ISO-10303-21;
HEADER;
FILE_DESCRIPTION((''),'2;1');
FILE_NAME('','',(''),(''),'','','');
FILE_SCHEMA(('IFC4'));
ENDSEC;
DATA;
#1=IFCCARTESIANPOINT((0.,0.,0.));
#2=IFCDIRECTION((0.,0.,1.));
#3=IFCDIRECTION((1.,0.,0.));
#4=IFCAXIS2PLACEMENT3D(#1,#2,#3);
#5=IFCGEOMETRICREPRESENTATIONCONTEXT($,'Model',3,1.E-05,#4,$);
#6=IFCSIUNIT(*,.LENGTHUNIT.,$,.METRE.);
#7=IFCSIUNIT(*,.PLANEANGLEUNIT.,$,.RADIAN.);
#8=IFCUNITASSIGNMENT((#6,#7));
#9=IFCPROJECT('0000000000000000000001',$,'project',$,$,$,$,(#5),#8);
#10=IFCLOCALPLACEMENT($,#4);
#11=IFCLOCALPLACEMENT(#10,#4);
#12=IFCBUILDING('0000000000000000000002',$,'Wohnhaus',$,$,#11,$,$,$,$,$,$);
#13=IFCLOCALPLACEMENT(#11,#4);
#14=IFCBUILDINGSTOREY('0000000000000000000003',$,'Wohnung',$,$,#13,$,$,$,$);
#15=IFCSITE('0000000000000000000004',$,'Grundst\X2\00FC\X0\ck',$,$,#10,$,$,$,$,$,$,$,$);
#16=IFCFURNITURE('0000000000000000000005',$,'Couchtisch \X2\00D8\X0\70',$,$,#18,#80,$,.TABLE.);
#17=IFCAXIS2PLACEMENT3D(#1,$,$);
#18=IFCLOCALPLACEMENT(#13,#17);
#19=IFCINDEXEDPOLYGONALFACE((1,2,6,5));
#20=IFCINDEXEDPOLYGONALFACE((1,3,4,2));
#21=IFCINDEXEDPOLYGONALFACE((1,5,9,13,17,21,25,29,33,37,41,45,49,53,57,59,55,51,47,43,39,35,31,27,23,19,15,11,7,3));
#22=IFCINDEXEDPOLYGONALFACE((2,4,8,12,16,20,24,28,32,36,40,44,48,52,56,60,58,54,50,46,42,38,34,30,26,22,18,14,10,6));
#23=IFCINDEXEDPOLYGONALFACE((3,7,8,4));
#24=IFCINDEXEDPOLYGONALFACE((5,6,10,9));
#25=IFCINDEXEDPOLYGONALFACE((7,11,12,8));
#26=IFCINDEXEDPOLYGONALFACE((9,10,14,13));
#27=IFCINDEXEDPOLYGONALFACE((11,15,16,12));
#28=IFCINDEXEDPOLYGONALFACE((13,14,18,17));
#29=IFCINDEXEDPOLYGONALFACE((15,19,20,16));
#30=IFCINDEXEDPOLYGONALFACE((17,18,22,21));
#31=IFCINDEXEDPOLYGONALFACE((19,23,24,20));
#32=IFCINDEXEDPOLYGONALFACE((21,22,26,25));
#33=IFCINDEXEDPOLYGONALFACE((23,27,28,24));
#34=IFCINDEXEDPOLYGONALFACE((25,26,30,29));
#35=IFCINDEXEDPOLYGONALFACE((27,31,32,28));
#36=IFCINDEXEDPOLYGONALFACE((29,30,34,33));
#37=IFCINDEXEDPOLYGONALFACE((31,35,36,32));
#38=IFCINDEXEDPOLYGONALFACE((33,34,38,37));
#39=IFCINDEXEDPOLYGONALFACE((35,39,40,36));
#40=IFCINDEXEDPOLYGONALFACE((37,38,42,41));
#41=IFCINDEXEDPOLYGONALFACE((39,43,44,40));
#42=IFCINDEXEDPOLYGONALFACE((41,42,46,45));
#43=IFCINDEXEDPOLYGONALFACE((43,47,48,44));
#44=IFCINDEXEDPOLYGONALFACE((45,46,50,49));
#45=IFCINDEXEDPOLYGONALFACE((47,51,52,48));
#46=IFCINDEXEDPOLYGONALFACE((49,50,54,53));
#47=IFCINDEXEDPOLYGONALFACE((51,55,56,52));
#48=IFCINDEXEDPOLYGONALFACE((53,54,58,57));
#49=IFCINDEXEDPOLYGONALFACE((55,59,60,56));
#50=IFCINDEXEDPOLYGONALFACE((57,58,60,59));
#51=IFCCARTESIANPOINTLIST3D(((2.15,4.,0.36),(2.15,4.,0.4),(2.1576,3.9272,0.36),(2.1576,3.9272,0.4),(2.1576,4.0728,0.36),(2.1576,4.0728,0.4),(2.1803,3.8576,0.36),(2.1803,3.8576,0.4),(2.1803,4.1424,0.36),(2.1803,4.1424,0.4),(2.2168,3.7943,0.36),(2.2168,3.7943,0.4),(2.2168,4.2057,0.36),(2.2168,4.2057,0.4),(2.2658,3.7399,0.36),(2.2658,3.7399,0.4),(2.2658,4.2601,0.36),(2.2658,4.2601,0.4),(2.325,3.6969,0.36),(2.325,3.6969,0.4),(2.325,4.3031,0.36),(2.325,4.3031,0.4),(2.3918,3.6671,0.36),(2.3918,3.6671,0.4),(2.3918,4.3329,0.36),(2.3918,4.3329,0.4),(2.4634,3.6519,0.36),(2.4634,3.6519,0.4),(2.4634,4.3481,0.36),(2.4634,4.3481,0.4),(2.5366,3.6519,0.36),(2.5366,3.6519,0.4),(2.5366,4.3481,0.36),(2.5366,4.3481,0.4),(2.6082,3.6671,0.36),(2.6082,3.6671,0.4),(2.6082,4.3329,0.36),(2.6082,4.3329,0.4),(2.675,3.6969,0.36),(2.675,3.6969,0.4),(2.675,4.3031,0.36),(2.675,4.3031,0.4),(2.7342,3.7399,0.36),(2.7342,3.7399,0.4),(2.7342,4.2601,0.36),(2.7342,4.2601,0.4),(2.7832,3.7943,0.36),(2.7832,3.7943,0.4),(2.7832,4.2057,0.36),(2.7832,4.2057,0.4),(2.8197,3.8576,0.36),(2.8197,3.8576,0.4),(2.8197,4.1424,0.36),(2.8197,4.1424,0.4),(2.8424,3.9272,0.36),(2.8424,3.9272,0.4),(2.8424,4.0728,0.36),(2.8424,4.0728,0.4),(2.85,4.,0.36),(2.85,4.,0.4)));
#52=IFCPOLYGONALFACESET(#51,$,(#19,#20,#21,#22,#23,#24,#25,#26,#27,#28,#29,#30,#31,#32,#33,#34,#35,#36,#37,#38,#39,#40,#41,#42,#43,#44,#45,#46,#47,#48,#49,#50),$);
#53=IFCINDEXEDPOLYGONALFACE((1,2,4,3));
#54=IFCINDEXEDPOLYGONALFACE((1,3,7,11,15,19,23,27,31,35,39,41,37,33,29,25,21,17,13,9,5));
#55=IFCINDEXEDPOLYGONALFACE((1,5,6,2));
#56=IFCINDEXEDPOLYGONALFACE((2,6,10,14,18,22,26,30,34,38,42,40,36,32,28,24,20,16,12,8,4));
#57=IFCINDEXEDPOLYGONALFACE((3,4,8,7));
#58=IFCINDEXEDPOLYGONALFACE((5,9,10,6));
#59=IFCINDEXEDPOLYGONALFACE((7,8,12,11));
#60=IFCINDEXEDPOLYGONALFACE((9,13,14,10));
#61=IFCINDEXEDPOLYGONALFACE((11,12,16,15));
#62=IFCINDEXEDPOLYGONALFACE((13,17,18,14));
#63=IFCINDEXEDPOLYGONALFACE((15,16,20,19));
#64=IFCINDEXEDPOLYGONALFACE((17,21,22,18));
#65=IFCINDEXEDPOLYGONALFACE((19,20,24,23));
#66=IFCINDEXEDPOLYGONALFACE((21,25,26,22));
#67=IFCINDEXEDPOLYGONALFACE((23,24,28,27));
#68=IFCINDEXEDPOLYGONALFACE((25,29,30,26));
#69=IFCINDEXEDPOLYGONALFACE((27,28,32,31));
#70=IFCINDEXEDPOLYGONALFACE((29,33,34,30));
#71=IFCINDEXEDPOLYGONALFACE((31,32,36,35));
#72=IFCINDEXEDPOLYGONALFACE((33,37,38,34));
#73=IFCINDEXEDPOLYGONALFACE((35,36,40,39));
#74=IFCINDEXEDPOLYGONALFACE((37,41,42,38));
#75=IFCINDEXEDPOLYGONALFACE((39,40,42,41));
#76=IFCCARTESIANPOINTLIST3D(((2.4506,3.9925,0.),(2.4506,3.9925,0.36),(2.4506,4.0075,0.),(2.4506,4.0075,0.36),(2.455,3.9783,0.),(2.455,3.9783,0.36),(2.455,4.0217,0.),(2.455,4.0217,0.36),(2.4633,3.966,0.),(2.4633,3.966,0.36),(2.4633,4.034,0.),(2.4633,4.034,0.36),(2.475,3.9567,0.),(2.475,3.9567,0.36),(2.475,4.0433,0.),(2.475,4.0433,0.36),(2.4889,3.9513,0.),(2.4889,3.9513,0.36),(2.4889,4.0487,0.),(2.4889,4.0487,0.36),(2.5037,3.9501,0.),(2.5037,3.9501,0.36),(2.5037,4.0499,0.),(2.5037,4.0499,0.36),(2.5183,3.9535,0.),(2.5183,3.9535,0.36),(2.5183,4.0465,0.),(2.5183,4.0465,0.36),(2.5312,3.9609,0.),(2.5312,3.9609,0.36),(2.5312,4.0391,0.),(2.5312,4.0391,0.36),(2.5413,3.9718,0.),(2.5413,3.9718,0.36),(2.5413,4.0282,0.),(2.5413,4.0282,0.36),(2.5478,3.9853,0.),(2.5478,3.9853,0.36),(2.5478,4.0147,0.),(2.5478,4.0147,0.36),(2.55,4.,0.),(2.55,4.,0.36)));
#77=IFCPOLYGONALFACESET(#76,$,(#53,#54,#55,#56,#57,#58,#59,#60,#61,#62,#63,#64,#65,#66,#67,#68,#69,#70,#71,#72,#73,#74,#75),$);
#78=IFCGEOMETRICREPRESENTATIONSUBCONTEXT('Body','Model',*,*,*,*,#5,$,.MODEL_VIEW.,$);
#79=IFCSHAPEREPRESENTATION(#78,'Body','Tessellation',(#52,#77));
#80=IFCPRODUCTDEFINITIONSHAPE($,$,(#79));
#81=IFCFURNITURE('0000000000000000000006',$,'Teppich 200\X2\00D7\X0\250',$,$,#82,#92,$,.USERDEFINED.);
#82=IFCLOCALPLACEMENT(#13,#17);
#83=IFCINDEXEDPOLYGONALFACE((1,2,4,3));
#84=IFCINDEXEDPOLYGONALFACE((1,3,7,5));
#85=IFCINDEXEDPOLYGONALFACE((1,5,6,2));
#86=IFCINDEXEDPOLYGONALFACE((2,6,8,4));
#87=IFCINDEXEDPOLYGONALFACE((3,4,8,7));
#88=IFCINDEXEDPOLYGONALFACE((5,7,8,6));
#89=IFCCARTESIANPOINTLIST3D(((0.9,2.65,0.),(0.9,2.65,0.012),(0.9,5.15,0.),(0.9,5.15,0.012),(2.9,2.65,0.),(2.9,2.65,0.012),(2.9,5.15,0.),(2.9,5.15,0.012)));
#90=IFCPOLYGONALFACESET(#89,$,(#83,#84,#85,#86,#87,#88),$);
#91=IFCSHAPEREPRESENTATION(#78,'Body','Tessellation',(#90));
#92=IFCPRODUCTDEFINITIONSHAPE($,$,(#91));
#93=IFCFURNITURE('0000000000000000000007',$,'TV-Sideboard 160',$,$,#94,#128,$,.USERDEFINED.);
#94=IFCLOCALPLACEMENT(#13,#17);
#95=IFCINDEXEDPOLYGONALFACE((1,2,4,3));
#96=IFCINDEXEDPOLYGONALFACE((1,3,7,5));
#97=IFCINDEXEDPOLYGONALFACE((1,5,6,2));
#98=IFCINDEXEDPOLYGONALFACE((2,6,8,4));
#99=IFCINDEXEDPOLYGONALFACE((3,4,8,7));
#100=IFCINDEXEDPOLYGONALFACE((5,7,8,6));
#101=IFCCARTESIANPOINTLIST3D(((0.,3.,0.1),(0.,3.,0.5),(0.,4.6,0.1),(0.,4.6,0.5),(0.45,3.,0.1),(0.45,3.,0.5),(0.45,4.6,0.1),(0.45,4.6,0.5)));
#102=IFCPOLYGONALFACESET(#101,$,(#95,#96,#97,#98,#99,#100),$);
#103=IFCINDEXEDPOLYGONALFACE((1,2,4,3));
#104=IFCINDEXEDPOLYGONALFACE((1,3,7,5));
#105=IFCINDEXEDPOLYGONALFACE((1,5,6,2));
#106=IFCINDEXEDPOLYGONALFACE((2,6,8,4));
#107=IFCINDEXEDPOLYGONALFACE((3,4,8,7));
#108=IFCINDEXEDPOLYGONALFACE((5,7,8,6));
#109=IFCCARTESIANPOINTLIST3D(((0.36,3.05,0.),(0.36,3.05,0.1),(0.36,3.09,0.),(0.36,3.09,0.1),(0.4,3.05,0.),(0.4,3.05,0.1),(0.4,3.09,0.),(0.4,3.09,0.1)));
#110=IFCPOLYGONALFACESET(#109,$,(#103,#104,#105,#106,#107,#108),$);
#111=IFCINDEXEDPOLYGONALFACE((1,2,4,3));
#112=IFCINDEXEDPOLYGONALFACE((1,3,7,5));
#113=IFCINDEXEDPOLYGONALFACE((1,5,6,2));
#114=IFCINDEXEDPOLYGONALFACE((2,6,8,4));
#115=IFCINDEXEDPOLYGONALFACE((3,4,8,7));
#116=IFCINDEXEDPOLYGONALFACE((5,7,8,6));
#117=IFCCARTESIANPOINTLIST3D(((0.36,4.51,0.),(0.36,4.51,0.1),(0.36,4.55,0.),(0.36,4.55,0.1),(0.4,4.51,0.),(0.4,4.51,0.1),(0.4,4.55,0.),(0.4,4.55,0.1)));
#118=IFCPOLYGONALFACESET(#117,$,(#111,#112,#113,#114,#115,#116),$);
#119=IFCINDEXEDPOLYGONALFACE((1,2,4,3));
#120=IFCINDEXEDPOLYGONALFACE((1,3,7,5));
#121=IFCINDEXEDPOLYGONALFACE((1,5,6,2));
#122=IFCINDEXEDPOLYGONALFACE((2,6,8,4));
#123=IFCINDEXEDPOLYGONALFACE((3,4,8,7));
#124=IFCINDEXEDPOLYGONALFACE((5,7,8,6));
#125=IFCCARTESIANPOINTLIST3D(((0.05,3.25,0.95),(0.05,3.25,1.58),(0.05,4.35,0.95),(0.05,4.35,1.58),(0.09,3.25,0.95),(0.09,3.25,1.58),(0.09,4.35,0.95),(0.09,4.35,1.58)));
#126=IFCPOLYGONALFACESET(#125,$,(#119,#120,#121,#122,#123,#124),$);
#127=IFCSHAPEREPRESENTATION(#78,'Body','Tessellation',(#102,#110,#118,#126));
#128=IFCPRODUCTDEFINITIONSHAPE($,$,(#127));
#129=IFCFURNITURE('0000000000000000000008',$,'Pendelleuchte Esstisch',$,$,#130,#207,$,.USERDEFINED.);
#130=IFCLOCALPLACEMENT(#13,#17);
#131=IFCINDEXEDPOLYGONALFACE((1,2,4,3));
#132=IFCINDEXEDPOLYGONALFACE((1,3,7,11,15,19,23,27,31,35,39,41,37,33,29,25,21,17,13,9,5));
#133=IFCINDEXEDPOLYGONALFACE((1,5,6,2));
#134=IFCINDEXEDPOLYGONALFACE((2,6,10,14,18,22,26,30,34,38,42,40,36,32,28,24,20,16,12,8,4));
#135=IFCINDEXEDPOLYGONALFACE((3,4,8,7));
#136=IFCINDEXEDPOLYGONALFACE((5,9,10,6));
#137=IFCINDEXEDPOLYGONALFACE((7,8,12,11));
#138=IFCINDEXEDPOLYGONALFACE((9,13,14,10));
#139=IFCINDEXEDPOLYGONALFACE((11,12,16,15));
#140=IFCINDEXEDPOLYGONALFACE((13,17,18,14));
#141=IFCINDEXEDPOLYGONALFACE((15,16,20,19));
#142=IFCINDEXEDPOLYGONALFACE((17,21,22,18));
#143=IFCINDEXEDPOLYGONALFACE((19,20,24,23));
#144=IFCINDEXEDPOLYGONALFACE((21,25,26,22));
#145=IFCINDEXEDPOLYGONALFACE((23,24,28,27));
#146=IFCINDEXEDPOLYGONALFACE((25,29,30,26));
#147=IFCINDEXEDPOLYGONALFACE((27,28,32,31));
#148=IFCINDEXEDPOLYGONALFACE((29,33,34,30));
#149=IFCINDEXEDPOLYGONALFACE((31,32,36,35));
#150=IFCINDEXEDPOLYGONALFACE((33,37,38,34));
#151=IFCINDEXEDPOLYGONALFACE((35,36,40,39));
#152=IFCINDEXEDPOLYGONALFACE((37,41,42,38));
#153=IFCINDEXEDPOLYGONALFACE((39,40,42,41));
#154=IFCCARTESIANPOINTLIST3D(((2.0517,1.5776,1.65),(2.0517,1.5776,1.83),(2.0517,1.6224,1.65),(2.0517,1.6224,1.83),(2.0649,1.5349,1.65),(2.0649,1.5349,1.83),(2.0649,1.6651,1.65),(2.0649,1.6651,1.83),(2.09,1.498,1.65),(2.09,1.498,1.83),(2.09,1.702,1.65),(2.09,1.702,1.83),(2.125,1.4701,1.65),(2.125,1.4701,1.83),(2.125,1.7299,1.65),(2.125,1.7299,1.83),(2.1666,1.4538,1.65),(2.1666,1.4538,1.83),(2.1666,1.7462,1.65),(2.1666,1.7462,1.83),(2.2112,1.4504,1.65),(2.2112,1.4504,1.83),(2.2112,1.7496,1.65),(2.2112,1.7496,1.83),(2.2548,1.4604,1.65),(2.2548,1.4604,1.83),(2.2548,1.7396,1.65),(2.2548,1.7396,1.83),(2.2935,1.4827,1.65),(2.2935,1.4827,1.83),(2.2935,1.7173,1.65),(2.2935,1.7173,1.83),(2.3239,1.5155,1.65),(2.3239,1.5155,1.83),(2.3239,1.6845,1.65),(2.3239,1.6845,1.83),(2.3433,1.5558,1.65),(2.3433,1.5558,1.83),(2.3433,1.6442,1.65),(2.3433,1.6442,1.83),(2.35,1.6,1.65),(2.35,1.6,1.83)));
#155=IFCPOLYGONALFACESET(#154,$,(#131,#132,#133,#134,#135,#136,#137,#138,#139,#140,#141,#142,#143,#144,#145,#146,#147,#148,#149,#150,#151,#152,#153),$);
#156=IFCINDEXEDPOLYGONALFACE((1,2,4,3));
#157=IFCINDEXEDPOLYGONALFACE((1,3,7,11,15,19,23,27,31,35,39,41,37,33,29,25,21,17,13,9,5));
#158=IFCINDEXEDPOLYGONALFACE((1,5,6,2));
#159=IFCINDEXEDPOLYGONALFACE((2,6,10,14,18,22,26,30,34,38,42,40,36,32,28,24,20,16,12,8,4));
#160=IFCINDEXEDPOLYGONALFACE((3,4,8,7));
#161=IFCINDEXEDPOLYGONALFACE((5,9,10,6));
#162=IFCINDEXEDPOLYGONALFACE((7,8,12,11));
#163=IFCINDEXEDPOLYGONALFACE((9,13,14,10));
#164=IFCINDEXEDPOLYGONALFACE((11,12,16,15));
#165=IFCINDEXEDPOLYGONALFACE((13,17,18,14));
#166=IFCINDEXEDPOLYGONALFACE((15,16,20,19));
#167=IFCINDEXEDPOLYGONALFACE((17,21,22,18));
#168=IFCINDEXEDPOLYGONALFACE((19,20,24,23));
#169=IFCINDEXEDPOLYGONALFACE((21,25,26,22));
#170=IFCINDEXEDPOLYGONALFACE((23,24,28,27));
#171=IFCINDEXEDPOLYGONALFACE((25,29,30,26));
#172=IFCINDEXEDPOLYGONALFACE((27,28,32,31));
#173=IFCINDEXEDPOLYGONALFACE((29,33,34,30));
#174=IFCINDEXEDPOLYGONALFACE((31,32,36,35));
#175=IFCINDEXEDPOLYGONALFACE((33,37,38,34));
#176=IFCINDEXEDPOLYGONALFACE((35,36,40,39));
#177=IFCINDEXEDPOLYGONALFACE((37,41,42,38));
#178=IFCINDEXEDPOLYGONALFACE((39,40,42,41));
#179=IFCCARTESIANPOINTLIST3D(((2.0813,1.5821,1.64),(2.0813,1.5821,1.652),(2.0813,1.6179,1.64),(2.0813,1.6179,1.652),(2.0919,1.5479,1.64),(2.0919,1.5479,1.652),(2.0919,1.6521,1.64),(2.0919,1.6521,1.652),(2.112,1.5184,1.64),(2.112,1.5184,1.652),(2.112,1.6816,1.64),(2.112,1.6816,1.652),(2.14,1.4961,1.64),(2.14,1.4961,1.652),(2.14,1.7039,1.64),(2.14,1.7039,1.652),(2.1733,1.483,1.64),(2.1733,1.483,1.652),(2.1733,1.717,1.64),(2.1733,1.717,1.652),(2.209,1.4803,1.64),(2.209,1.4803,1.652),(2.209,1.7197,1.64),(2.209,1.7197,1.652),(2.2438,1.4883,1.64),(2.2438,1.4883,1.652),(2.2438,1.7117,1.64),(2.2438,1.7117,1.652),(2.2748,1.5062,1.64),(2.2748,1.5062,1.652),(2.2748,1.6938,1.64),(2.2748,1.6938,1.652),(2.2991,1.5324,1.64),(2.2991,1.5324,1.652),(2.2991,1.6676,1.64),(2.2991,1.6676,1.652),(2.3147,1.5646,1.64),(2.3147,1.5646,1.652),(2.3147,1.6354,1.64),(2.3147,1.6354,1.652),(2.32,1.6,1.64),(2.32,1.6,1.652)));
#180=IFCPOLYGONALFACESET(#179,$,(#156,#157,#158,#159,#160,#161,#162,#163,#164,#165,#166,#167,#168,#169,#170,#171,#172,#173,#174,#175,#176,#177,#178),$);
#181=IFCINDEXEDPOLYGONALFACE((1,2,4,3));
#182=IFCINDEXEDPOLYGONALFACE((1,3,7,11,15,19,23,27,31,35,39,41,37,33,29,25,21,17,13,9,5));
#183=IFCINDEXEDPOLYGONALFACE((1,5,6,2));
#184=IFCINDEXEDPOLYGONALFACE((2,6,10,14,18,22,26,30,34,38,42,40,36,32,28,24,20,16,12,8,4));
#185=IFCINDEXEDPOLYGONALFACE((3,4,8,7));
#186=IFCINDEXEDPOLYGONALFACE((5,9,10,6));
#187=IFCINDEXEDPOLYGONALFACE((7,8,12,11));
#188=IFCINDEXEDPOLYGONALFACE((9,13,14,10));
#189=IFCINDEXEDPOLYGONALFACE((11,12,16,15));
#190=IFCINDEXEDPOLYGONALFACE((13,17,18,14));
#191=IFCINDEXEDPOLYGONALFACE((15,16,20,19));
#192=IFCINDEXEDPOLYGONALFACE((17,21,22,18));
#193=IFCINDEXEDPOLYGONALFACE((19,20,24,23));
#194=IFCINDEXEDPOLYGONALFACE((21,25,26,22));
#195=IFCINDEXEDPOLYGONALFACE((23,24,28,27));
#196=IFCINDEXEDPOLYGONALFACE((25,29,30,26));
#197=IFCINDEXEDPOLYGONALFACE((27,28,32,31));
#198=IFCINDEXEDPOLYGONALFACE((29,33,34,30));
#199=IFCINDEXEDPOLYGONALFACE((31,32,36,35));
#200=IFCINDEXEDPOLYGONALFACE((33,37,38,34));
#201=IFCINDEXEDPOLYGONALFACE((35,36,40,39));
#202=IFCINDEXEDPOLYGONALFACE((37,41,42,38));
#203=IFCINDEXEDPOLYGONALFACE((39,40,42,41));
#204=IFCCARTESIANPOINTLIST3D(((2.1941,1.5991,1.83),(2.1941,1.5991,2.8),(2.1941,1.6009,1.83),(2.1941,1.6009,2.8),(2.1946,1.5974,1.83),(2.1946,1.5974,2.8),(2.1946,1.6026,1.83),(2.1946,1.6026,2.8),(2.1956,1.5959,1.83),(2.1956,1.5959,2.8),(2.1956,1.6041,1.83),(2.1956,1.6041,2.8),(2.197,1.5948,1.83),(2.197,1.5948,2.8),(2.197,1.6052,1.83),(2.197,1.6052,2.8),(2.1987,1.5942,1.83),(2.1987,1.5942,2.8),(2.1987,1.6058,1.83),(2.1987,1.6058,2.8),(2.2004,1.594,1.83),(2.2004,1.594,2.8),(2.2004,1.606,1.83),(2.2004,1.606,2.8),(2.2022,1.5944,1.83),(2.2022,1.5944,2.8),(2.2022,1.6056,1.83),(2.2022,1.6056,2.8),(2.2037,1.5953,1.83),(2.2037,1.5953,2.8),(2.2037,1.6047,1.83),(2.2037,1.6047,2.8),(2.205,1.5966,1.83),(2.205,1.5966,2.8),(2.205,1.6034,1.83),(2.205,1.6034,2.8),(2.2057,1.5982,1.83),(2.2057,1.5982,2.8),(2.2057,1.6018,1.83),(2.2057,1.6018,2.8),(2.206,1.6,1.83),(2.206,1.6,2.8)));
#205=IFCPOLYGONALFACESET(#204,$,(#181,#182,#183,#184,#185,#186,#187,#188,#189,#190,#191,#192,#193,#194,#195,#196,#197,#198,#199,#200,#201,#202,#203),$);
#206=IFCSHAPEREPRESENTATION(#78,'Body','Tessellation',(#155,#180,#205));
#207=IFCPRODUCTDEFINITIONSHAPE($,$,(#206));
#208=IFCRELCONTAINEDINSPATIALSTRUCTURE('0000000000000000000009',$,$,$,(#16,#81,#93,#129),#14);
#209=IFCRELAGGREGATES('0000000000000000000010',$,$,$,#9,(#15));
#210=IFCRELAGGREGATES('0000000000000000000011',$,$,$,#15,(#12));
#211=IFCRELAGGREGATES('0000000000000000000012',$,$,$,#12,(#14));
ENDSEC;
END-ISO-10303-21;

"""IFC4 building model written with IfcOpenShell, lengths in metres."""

from ifc_helpers import new_model, si_unit, frame, frame_2d, origin, origin_with_axes, place, context, subcontext, project, spatial, rectangle, circle, extrude, element, save


model = new_model("IFC4")

# Units and contexts
model_context = context("Model", 3, precision=1e-05, world=origin_with_axes())
body_context = subcontext(model_context, "Body", "Model", "MODEL_VIEW")
ifc_project = project(units=[si_unit("LENGTHUNIT", "METRE"), si_unit("PLANEANGLEUNIT", "RADIAN")], contexts=[model_context])

# Site, building, storey
site_placement = place(None, origin_with_axes())
site = spatial("IfcSite", under=ifc_project, at=site_placement, Name="Grundstück")
building_placement = place(site_placement, origin_with_axes())
building = spatial("IfcBuilding", under=site, at=building_placement, Name="Wohnhaus")
storey_placement = place(building_placement, origin_with_axes())
storey = spatial("IfcBuildingStorey", under=building, at=storey_placement, Name="Wohnung")

# Furniture
furniture_1_placement = place(storey_placement, frame((2.15, 3.65, 0.0), z_axis=(0.0, 0.0, 1.0), x_axis=(1.0, 0.0, 0.0)))
element("IfcFurniture", 1, at=furniture_1_placement, inside=storey, Name="Couchtisch Ø70", PredefinedType="TABLE", context=body_context, shape_type="SweptSolid", body=[
    extrude(circle(Radius=0.35, at=frame_2d((0.35, 0.35))), frame((0.0, 0.0, 0.36)), (0.0, 0.0, 1.0), 0.04),
    extrude(circle(Radius=0.05, at=frame_2d((0.35, 0.35))), origin(), (0.0, 0.0, 1.0), 0.36),
])
furniture_2_placement = place(storey_placement, frame((0.9, 2.65, 0.0), z_axis=(0.0, 0.0, 1.0), x_axis=(1.0, 0.0, 0.0)))
element("IfcFurniture", 2, at=furniture_2_placement, inside=storey, Name="Teppich 200×250", PredefinedType="USERDEFINED", context=body_context, shape_type="SweptSolid", body=[
    extrude(rectangle(XDim=2.0, YDim=2.5, at=frame_2d((1.0, 1.25))), origin(), (0.0, 0.0, 1.0), 0.012),
])
furniture_3_placement = place(storey_placement, frame((0.45, 3.0, 0.0), z_axis=(0.0, 0.0, 1.0), x_axis=(0.0, 1.0, 0.0)))
element("IfcFurniture", 3, at=furniture_3_placement, inside=storey, Name="TV-Sideboard 160", PredefinedType="USERDEFINED", context=body_context, shape_type="SweptSolid", body=[
    extrude(rectangle(XDim=1.6, YDim=0.45, at=frame_2d((0.8, 0.225))), frame((0.0, 0.0, 0.1)), (0.0, 0.0, 1.0), 0.4),
    extrude(rectangle(XDim=0.04, YDim=0.04, at=frame_2d((0.07, 0.07))), origin(), (0.0, 0.0, 1.0), 0.1),
    extrude(rectangle(XDim=0.04, YDim=0.04, at=frame_2d((1.53, 0.07))), origin(), (0.0, 0.0, 1.0), 0.1),
    extrude(rectangle(XDim=1.1, YDim=0.04, at=frame_2d((0.8, 0.38))), frame((0.0, 0.0, 0.95)), (0.0, 0.0, 1.0), 0.63),
])
furniture_4_placement = place(storey_placement, frame((2.05, 1.45, 0.0), z_axis=(0.0, 0.0, 1.0), x_axis=(1.0, 0.0, 0.0)))
element("IfcFurniture", 4, at=furniture_4_placement, inside=storey, Name="Pendelleuchte Esstisch", PredefinedType="USERDEFINED", context=body_context, shape_type="SweptSolid", body=[
    extrude(circle(Radius=0.15, at=frame_2d((0.15, 0.15))), frame((0.0, 0.0, 1.65)), (0.0, 0.0, 1.0), 0.18),
    extrude(circle(Radius=0.12, at=frame_2d((0.15, 0.15))), frame((0.0, 0.0, 1.64)), (0.0, 0.0, 1.0), 0.012),
    extrude(circle(Radius=0.006, at=frame_2d((0.15, 0.15))), frame((0.0, 0.0, 1.83)), (0.0, 0.0, 1.0), 0.97),
])

save(model, "model.ifc")
